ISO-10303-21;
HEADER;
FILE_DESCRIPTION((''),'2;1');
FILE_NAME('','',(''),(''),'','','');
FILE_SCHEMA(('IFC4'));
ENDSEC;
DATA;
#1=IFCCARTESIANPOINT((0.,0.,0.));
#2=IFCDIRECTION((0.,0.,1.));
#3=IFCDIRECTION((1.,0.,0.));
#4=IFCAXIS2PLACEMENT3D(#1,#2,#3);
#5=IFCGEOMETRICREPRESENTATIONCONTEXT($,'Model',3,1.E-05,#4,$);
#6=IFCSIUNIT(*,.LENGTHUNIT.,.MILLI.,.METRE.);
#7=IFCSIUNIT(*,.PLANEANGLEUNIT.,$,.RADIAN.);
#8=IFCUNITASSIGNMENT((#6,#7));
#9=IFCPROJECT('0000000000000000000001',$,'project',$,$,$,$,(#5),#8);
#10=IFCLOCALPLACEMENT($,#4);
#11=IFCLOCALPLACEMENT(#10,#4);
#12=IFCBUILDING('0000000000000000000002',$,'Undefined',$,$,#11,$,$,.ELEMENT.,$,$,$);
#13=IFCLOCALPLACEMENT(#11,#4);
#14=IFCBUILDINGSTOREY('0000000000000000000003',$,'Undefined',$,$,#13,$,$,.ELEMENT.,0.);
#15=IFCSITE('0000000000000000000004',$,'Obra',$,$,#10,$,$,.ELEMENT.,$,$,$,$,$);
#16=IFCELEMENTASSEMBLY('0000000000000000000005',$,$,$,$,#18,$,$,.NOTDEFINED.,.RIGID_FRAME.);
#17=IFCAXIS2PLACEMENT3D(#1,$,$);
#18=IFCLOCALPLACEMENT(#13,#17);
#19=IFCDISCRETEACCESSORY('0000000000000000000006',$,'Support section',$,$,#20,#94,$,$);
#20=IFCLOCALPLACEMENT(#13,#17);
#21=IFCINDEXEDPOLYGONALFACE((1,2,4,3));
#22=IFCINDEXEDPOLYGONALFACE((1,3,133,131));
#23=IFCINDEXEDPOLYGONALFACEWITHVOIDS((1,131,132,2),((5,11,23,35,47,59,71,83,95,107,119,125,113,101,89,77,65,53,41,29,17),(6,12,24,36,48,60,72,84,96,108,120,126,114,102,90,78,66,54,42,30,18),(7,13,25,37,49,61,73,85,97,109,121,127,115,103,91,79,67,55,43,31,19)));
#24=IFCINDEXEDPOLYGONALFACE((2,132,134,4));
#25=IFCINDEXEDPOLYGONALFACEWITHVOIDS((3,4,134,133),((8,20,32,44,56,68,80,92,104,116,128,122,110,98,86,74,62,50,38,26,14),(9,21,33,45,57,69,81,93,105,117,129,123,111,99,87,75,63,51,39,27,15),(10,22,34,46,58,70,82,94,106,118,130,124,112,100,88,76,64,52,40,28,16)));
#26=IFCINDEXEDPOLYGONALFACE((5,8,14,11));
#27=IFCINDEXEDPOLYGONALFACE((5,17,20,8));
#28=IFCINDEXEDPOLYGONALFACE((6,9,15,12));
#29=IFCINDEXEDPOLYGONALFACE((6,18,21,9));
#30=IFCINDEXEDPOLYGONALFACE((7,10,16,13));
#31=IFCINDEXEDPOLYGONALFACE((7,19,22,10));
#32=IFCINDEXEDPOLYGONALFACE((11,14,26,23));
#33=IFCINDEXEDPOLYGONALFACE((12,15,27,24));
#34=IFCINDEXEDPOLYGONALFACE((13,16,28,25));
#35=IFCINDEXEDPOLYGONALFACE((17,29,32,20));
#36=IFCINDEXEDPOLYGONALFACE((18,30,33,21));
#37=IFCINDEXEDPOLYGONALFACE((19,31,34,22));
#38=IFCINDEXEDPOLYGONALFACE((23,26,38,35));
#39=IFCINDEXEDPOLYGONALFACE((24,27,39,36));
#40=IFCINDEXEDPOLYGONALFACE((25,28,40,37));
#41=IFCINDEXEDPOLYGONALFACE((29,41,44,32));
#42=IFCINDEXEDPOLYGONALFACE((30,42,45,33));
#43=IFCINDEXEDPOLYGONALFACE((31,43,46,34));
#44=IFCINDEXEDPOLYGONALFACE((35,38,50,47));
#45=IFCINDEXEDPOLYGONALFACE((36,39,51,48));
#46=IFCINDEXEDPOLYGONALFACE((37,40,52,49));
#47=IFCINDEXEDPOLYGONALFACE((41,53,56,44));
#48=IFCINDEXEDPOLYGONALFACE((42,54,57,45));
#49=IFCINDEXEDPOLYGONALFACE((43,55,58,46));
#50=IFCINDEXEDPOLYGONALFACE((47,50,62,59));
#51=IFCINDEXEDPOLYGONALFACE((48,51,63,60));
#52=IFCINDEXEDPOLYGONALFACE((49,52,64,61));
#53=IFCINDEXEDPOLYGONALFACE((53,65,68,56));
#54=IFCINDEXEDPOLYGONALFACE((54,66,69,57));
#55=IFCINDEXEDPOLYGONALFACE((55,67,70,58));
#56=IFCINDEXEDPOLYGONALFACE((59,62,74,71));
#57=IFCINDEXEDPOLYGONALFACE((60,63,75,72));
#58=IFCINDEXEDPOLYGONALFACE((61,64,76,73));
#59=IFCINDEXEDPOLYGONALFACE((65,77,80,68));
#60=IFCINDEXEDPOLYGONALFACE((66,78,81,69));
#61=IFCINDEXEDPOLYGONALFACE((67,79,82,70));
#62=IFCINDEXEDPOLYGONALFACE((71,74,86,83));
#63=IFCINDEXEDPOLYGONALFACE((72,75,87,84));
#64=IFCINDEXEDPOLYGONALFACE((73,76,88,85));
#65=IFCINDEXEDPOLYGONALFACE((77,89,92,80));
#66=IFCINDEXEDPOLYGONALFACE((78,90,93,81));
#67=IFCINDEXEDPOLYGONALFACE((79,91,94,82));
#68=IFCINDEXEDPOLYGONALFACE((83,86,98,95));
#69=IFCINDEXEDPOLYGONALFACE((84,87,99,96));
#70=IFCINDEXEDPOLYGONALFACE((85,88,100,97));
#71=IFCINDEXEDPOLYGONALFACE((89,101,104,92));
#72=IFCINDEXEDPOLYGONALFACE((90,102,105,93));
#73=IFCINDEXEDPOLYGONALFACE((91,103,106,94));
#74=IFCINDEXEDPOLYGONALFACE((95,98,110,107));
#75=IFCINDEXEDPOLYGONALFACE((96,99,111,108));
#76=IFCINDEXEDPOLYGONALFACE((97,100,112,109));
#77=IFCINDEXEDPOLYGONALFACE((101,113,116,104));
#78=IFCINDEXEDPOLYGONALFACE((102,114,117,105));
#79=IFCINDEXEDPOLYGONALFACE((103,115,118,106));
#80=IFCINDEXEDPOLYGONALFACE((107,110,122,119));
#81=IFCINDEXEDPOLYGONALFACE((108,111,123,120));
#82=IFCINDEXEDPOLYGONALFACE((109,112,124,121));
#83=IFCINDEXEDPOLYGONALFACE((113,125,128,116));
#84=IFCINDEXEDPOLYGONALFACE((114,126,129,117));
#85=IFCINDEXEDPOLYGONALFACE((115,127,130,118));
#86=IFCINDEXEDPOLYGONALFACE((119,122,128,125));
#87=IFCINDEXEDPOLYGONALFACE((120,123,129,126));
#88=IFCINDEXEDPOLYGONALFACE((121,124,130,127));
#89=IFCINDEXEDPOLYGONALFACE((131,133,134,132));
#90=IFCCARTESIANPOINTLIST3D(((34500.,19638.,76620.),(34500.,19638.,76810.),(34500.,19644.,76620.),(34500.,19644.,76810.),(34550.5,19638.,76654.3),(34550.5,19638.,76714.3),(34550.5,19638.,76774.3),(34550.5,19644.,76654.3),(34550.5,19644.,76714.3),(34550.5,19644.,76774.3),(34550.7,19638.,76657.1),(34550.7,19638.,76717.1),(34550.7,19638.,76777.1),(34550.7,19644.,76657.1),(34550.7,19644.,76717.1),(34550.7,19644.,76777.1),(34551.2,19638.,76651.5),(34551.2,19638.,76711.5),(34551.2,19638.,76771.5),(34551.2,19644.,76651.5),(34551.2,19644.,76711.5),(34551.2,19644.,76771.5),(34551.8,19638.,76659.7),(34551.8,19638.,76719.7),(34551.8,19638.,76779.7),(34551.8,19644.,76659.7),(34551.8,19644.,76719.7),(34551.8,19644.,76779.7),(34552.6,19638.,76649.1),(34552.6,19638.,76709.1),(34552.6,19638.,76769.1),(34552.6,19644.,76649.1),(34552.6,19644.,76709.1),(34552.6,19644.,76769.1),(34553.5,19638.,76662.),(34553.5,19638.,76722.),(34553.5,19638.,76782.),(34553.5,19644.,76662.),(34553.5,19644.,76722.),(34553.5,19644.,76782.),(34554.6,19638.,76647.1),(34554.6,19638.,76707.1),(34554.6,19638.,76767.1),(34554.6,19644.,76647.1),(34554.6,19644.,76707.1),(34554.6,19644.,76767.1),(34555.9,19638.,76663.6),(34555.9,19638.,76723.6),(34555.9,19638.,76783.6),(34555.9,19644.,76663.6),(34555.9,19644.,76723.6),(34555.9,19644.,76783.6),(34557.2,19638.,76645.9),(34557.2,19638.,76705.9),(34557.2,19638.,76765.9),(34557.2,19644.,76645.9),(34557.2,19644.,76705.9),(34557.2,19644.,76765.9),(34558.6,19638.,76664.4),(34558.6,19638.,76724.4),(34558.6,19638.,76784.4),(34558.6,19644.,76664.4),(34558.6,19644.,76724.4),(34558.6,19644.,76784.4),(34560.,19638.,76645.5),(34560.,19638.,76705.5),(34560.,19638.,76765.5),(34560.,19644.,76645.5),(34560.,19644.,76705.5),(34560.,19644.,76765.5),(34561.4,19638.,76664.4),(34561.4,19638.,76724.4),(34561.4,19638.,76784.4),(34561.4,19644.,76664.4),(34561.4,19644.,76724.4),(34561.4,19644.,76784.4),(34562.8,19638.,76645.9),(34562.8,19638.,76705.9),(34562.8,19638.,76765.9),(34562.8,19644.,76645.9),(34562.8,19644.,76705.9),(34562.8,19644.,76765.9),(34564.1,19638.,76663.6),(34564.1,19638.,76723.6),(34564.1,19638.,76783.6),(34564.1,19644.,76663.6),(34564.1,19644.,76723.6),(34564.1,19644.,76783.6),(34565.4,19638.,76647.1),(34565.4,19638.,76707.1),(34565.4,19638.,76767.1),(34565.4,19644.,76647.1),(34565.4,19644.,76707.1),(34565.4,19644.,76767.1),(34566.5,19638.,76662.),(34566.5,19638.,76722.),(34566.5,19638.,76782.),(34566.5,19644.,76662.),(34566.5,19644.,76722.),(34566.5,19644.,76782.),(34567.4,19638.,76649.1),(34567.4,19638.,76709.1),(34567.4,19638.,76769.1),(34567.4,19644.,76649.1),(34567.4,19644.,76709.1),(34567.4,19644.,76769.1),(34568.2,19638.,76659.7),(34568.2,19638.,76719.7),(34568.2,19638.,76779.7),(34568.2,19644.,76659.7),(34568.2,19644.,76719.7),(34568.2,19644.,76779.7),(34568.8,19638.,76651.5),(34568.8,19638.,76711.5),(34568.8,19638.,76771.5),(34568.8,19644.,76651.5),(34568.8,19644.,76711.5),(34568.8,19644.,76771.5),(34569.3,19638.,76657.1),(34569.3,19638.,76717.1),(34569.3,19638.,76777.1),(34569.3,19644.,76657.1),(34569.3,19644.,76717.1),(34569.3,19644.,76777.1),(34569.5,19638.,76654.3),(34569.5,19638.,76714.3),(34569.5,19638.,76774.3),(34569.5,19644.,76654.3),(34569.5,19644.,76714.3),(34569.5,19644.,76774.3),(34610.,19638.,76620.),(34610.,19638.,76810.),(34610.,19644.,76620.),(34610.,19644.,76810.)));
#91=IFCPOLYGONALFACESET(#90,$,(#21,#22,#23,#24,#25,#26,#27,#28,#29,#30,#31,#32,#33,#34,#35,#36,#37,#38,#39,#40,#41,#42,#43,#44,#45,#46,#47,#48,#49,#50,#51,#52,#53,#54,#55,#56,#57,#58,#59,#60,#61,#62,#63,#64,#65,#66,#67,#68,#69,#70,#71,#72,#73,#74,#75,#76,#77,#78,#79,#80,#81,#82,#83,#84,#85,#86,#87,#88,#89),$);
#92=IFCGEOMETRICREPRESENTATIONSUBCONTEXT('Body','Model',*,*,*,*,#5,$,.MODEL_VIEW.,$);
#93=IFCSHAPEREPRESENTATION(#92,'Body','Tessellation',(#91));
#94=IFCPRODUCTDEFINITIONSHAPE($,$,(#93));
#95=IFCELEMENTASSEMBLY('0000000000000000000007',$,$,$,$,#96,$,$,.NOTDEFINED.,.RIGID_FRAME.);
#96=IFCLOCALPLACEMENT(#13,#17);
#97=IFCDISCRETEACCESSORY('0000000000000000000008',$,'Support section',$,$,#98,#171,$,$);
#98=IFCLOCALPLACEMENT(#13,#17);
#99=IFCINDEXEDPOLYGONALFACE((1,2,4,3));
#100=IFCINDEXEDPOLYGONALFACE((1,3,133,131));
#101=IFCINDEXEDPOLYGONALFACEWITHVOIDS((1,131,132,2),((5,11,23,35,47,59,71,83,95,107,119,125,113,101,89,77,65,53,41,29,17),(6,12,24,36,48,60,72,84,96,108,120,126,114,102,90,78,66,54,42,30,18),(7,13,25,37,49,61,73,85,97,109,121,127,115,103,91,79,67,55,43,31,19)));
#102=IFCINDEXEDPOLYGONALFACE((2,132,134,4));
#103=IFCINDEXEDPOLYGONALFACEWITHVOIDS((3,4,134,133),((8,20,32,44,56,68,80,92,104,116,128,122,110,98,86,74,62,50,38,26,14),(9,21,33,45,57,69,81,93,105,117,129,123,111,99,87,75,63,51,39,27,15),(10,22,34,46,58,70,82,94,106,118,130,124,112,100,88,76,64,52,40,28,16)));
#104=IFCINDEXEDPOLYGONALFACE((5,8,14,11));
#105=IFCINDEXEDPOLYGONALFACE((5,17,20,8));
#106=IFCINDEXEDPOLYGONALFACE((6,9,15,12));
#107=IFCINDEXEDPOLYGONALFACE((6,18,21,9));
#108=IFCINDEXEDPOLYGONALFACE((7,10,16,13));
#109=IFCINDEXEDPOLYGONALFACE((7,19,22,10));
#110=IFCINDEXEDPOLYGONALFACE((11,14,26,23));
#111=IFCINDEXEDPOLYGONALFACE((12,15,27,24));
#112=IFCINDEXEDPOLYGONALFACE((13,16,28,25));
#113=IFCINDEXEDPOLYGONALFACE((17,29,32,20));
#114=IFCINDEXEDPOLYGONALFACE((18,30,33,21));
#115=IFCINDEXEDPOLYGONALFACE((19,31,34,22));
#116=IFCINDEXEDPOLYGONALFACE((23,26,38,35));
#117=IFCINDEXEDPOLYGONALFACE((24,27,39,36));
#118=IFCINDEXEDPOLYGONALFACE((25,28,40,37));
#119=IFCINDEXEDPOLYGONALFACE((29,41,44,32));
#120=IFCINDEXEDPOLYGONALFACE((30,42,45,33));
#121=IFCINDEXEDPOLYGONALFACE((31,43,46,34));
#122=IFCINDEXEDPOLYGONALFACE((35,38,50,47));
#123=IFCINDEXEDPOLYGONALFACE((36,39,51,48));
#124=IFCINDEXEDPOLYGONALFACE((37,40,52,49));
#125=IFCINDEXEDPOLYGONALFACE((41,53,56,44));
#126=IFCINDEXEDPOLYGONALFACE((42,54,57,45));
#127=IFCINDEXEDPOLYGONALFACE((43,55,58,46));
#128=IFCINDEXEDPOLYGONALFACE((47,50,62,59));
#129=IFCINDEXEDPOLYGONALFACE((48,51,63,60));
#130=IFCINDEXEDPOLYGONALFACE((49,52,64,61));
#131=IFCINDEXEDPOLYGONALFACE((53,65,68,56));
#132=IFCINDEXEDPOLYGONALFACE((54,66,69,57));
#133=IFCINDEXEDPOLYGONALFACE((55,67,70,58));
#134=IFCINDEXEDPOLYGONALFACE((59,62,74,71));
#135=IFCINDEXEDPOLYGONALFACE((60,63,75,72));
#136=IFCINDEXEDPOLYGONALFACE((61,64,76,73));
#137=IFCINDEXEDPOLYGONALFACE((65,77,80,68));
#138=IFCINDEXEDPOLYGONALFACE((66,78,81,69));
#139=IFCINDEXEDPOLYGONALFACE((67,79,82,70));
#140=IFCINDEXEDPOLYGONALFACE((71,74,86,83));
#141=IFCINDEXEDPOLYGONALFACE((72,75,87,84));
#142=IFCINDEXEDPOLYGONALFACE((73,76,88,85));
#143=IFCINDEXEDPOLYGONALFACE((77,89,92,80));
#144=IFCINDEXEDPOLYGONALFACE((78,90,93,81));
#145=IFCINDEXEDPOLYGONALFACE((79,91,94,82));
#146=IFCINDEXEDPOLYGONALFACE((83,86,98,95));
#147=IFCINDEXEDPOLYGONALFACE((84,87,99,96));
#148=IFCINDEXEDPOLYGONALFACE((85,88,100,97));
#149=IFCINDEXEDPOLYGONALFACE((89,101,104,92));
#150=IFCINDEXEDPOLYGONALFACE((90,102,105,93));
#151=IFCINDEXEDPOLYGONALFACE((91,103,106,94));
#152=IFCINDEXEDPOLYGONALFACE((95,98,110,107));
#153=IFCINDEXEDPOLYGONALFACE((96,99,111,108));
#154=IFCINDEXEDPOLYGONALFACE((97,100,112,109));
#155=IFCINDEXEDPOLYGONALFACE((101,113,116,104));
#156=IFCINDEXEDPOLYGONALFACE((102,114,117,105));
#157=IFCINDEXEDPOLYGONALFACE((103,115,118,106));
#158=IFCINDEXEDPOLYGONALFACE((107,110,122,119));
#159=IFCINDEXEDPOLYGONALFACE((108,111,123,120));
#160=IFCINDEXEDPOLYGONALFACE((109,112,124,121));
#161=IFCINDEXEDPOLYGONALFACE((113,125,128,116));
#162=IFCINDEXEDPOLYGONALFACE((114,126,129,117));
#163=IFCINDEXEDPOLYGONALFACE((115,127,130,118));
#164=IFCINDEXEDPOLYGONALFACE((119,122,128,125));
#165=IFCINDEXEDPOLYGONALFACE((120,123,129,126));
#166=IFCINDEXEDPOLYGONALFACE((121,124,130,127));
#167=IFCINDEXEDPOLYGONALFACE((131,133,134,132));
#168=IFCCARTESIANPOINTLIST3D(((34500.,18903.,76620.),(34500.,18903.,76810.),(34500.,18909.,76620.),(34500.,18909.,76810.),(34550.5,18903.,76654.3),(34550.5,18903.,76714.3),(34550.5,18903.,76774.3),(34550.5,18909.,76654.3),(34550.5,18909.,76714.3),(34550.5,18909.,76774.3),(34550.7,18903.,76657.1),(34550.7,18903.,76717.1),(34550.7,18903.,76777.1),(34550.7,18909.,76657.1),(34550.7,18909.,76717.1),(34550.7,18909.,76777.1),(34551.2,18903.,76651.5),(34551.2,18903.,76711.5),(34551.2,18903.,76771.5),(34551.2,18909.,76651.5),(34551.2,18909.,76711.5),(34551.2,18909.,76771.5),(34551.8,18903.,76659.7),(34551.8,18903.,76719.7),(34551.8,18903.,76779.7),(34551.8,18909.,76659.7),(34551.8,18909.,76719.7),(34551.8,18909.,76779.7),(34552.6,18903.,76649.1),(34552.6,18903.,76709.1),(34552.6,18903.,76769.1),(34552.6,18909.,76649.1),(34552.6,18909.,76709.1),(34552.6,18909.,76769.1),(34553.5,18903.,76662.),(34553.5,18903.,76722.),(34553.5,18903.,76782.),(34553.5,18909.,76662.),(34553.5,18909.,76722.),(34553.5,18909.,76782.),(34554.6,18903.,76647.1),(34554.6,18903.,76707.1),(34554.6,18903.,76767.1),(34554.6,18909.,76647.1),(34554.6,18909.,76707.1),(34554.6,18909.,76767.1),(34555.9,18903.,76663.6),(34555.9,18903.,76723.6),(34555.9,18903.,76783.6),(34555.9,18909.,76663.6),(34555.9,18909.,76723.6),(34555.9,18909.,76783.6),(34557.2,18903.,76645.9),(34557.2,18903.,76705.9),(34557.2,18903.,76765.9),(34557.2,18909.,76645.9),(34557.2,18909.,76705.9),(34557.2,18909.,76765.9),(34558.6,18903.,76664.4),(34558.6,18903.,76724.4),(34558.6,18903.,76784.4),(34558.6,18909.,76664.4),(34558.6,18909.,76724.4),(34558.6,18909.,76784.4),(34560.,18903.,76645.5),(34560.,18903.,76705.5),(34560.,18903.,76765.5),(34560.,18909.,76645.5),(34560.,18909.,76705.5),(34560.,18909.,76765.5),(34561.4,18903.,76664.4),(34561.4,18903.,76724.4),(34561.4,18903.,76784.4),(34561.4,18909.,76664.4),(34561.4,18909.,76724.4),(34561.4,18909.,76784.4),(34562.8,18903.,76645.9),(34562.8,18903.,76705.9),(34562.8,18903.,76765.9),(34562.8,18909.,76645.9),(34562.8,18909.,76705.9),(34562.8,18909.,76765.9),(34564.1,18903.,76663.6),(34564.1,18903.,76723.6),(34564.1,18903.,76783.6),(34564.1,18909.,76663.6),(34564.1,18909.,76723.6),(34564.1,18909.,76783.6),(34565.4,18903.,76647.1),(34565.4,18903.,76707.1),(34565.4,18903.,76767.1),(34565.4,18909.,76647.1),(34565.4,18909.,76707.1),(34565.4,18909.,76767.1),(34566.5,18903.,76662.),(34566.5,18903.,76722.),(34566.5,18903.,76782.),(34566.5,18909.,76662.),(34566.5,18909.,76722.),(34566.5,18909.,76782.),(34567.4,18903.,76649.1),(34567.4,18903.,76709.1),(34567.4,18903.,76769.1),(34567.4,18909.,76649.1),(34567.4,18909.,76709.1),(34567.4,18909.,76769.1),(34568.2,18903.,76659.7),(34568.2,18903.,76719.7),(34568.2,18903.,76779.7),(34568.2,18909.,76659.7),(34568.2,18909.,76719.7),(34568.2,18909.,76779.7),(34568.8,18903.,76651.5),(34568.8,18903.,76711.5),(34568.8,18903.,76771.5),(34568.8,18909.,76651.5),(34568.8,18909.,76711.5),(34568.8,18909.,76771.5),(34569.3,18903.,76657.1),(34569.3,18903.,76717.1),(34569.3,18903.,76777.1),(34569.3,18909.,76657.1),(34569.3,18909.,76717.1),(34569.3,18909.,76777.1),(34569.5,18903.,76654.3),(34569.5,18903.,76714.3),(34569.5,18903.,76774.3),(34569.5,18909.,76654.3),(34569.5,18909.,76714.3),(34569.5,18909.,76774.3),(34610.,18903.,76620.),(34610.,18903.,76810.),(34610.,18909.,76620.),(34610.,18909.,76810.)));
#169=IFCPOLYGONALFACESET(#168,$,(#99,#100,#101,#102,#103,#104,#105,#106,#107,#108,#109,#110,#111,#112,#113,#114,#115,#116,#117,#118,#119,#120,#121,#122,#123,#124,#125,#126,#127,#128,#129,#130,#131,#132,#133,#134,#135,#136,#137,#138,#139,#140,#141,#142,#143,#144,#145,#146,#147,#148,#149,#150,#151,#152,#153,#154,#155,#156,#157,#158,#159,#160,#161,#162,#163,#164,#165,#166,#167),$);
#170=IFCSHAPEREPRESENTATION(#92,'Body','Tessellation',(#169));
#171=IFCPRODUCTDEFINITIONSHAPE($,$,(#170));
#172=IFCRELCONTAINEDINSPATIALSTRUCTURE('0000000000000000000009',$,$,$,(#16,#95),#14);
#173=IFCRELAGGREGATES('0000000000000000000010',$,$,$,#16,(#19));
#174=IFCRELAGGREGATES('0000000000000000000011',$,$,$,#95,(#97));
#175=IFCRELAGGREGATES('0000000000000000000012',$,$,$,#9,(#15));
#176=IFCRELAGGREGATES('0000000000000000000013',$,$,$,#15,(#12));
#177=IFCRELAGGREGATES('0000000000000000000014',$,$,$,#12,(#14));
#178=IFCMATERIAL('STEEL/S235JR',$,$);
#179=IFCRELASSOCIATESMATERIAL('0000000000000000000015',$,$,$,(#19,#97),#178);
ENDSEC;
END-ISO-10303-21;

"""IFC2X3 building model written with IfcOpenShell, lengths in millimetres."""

from ifc_helpers import new_model, si_unit, frame, origin_with_axes, origin_2d_with_axis, place, context, subcontext, project, spatial, rectangle, circle, extrude, source, transform, mapped, material, element, aggregate, save


model = new_model("IFC2X3")

# Units and contexts
model_context = context("Model", 3, precision=1e-05, world=origin_with_axes())
body_context = subcontext(model_context, "Body", "Model", "MODEL_VIEW")
ifc_project = project(units=[si_unit("LENGTHUNIT", "METRE", prefix="MILLI"), si_unit("PLANEANGLEUNIT", "RADIAN")], contexts=[model_context])

# Site, building, storey
site_placement = place(None, origin_with_axes())
site = spatial("IfcSite", under=ifc_project, at=site_placement, Name="Obra", CompositionType="ELEMENT")
building_placement = place(site_placement, origin_with_axes())
building = spatial("IfcBuilding", under=site, at=building_placement, Name="Undefined", CompositionType="ELEMENT")
storey_placement = place(building_placement, origin_with_axes())
storey = spatial("IfcBuildingStorey", under=building, at=storey_placement, Name="Undefined", CompositionType="ELEMENT", Elevation=0.0)

# Shared definitions
ifc_material = material(Name="STEEL/S235JR")

# Element assemblies, discrete accessories, openings
assembly_1_placement = place(storey_placement, origin_with_axes())
assembly_1 = element("IfcElementAssembly", 1, at=assembly_1_placement, inside=storey, AssemblyPlace="NOTDEFINED", PredefinedType="RIGID_FRAME")
discrete_accessory_1_placement = place(assembly_1_placement, frame((34555.0, 19641.0, 76620.0), z_axis=(0.0, 0.0, 1.0), x_axis=(-1.0, 0.0, 0.0)))
discrete_accessory_1 = element("IfcDiscreteAccessory", 2, at=discrete_accessory_1_placement, material=ifc_material, Name="Support section", context=body_context, shape_type="SweptSolid", body=[
    extrude(rectangle(XDim=6.0, YDim=110.0, at=origin_2d_with_axis()), frame((0.0, 0.0, 190.0), z_axis=(0.0, 0.0, -1.0), x_axis=(0.0, 1.0, 0.0)), (0.0, 0.0, 1.0), 190.0),
])
shared_shape_1 = source(origin_with_axes(), body_context, "Body", "SweptSolid", [
    extrude(circle(Radius=9.5, at=origin_2d_with_axis()), frame((0.0, -9.2, 0.0), z_axis=(0.0, 1.0, 0.0), x_axis=(1.0, 0.0, 0.0)), (0.0, 0.0, 1.0), 6.2),
])
opening_1_placement = place(assembly_1_placement, frame((34510.0, 19647.1, 76835.0), z_axis=(1.0, 0.0, 0.0), x_axis=(0.0, 0.0, -1.0)))
element("IfcOpeningElement", 3, at=opening_1_placement, cuts=discrete_accessory_1, ObjectType="Opening", context=body_context, shape_type="MappedRepresentation", body=[
    mapped(shared_shape_1, transform((60.0, 0.0, 50.0))),
    mapped(shared_shape_1, transform((120.0, 0.0, 50.0))),
    mapped(shared_shape_1, transform((180.0, 0.0, 50.0))),
])
aggregate(assembly_1, [discrete_accessory_1])
assembly_2_placement = place(storey_placement, origin_with_axes())
assembly_2 = element("IfcElementAssembly", 4, at=assembly_2_placement, inside=storey, AssemblyPlace="NOTDEFINED", PredefinedType="RIGID_FRAME")
discrete_accessory_2_placement = place(assembly_2_placement, frame((34555.0, 18906.0, 76620.0), z_axis=(0.0, 0.0, 1.0), x_axis=(-1.0, 0.0, 0.0)))
discrete_accessory_2 = element("IfcDiscreteAccessory", 5, at=discrete_accessory_2_placement, material=ifc_material, Name="Support section", context=body_context, shape_type="SweptSolid", body=[
    extrude(rectangle(XDim=6.0, YDim=110.0, at=origin_2d_with_axis()), frame((0.0, 0.0, 190.0), z_axis=(0.0, 0.0, -1.0), x_axis=(0.0, 1.0, 0.0)), (0.0, 0.0, 1.0), 190.0),
])
opening_2_placement = place(assembly_2_placement, frame((34510.0, 18912.1, 76835.0), z_axis=(1.0, 0.0, 0.0), x_axis=(0.0, 0.0, -1.0)))
element("IfcOpeningElement", 6, at=opening_2_placement, cuts=discrete_accessory_2, ObjectType="Opening", context=body_context, shape_type="MappedRepresentation", body=[
    mapped(shared_shape_1, transform((60.0, 0.0, 50.0))),
    mapped(shared_shape_1, transform((120.0, 0.0, 50.0))),
    mapped(shared_shape_1, transform((180.0, 0.0, 50.0))),
])
aggregate(assembly_2, [discrete_accessory_2])

save(model, "model.ifc")
